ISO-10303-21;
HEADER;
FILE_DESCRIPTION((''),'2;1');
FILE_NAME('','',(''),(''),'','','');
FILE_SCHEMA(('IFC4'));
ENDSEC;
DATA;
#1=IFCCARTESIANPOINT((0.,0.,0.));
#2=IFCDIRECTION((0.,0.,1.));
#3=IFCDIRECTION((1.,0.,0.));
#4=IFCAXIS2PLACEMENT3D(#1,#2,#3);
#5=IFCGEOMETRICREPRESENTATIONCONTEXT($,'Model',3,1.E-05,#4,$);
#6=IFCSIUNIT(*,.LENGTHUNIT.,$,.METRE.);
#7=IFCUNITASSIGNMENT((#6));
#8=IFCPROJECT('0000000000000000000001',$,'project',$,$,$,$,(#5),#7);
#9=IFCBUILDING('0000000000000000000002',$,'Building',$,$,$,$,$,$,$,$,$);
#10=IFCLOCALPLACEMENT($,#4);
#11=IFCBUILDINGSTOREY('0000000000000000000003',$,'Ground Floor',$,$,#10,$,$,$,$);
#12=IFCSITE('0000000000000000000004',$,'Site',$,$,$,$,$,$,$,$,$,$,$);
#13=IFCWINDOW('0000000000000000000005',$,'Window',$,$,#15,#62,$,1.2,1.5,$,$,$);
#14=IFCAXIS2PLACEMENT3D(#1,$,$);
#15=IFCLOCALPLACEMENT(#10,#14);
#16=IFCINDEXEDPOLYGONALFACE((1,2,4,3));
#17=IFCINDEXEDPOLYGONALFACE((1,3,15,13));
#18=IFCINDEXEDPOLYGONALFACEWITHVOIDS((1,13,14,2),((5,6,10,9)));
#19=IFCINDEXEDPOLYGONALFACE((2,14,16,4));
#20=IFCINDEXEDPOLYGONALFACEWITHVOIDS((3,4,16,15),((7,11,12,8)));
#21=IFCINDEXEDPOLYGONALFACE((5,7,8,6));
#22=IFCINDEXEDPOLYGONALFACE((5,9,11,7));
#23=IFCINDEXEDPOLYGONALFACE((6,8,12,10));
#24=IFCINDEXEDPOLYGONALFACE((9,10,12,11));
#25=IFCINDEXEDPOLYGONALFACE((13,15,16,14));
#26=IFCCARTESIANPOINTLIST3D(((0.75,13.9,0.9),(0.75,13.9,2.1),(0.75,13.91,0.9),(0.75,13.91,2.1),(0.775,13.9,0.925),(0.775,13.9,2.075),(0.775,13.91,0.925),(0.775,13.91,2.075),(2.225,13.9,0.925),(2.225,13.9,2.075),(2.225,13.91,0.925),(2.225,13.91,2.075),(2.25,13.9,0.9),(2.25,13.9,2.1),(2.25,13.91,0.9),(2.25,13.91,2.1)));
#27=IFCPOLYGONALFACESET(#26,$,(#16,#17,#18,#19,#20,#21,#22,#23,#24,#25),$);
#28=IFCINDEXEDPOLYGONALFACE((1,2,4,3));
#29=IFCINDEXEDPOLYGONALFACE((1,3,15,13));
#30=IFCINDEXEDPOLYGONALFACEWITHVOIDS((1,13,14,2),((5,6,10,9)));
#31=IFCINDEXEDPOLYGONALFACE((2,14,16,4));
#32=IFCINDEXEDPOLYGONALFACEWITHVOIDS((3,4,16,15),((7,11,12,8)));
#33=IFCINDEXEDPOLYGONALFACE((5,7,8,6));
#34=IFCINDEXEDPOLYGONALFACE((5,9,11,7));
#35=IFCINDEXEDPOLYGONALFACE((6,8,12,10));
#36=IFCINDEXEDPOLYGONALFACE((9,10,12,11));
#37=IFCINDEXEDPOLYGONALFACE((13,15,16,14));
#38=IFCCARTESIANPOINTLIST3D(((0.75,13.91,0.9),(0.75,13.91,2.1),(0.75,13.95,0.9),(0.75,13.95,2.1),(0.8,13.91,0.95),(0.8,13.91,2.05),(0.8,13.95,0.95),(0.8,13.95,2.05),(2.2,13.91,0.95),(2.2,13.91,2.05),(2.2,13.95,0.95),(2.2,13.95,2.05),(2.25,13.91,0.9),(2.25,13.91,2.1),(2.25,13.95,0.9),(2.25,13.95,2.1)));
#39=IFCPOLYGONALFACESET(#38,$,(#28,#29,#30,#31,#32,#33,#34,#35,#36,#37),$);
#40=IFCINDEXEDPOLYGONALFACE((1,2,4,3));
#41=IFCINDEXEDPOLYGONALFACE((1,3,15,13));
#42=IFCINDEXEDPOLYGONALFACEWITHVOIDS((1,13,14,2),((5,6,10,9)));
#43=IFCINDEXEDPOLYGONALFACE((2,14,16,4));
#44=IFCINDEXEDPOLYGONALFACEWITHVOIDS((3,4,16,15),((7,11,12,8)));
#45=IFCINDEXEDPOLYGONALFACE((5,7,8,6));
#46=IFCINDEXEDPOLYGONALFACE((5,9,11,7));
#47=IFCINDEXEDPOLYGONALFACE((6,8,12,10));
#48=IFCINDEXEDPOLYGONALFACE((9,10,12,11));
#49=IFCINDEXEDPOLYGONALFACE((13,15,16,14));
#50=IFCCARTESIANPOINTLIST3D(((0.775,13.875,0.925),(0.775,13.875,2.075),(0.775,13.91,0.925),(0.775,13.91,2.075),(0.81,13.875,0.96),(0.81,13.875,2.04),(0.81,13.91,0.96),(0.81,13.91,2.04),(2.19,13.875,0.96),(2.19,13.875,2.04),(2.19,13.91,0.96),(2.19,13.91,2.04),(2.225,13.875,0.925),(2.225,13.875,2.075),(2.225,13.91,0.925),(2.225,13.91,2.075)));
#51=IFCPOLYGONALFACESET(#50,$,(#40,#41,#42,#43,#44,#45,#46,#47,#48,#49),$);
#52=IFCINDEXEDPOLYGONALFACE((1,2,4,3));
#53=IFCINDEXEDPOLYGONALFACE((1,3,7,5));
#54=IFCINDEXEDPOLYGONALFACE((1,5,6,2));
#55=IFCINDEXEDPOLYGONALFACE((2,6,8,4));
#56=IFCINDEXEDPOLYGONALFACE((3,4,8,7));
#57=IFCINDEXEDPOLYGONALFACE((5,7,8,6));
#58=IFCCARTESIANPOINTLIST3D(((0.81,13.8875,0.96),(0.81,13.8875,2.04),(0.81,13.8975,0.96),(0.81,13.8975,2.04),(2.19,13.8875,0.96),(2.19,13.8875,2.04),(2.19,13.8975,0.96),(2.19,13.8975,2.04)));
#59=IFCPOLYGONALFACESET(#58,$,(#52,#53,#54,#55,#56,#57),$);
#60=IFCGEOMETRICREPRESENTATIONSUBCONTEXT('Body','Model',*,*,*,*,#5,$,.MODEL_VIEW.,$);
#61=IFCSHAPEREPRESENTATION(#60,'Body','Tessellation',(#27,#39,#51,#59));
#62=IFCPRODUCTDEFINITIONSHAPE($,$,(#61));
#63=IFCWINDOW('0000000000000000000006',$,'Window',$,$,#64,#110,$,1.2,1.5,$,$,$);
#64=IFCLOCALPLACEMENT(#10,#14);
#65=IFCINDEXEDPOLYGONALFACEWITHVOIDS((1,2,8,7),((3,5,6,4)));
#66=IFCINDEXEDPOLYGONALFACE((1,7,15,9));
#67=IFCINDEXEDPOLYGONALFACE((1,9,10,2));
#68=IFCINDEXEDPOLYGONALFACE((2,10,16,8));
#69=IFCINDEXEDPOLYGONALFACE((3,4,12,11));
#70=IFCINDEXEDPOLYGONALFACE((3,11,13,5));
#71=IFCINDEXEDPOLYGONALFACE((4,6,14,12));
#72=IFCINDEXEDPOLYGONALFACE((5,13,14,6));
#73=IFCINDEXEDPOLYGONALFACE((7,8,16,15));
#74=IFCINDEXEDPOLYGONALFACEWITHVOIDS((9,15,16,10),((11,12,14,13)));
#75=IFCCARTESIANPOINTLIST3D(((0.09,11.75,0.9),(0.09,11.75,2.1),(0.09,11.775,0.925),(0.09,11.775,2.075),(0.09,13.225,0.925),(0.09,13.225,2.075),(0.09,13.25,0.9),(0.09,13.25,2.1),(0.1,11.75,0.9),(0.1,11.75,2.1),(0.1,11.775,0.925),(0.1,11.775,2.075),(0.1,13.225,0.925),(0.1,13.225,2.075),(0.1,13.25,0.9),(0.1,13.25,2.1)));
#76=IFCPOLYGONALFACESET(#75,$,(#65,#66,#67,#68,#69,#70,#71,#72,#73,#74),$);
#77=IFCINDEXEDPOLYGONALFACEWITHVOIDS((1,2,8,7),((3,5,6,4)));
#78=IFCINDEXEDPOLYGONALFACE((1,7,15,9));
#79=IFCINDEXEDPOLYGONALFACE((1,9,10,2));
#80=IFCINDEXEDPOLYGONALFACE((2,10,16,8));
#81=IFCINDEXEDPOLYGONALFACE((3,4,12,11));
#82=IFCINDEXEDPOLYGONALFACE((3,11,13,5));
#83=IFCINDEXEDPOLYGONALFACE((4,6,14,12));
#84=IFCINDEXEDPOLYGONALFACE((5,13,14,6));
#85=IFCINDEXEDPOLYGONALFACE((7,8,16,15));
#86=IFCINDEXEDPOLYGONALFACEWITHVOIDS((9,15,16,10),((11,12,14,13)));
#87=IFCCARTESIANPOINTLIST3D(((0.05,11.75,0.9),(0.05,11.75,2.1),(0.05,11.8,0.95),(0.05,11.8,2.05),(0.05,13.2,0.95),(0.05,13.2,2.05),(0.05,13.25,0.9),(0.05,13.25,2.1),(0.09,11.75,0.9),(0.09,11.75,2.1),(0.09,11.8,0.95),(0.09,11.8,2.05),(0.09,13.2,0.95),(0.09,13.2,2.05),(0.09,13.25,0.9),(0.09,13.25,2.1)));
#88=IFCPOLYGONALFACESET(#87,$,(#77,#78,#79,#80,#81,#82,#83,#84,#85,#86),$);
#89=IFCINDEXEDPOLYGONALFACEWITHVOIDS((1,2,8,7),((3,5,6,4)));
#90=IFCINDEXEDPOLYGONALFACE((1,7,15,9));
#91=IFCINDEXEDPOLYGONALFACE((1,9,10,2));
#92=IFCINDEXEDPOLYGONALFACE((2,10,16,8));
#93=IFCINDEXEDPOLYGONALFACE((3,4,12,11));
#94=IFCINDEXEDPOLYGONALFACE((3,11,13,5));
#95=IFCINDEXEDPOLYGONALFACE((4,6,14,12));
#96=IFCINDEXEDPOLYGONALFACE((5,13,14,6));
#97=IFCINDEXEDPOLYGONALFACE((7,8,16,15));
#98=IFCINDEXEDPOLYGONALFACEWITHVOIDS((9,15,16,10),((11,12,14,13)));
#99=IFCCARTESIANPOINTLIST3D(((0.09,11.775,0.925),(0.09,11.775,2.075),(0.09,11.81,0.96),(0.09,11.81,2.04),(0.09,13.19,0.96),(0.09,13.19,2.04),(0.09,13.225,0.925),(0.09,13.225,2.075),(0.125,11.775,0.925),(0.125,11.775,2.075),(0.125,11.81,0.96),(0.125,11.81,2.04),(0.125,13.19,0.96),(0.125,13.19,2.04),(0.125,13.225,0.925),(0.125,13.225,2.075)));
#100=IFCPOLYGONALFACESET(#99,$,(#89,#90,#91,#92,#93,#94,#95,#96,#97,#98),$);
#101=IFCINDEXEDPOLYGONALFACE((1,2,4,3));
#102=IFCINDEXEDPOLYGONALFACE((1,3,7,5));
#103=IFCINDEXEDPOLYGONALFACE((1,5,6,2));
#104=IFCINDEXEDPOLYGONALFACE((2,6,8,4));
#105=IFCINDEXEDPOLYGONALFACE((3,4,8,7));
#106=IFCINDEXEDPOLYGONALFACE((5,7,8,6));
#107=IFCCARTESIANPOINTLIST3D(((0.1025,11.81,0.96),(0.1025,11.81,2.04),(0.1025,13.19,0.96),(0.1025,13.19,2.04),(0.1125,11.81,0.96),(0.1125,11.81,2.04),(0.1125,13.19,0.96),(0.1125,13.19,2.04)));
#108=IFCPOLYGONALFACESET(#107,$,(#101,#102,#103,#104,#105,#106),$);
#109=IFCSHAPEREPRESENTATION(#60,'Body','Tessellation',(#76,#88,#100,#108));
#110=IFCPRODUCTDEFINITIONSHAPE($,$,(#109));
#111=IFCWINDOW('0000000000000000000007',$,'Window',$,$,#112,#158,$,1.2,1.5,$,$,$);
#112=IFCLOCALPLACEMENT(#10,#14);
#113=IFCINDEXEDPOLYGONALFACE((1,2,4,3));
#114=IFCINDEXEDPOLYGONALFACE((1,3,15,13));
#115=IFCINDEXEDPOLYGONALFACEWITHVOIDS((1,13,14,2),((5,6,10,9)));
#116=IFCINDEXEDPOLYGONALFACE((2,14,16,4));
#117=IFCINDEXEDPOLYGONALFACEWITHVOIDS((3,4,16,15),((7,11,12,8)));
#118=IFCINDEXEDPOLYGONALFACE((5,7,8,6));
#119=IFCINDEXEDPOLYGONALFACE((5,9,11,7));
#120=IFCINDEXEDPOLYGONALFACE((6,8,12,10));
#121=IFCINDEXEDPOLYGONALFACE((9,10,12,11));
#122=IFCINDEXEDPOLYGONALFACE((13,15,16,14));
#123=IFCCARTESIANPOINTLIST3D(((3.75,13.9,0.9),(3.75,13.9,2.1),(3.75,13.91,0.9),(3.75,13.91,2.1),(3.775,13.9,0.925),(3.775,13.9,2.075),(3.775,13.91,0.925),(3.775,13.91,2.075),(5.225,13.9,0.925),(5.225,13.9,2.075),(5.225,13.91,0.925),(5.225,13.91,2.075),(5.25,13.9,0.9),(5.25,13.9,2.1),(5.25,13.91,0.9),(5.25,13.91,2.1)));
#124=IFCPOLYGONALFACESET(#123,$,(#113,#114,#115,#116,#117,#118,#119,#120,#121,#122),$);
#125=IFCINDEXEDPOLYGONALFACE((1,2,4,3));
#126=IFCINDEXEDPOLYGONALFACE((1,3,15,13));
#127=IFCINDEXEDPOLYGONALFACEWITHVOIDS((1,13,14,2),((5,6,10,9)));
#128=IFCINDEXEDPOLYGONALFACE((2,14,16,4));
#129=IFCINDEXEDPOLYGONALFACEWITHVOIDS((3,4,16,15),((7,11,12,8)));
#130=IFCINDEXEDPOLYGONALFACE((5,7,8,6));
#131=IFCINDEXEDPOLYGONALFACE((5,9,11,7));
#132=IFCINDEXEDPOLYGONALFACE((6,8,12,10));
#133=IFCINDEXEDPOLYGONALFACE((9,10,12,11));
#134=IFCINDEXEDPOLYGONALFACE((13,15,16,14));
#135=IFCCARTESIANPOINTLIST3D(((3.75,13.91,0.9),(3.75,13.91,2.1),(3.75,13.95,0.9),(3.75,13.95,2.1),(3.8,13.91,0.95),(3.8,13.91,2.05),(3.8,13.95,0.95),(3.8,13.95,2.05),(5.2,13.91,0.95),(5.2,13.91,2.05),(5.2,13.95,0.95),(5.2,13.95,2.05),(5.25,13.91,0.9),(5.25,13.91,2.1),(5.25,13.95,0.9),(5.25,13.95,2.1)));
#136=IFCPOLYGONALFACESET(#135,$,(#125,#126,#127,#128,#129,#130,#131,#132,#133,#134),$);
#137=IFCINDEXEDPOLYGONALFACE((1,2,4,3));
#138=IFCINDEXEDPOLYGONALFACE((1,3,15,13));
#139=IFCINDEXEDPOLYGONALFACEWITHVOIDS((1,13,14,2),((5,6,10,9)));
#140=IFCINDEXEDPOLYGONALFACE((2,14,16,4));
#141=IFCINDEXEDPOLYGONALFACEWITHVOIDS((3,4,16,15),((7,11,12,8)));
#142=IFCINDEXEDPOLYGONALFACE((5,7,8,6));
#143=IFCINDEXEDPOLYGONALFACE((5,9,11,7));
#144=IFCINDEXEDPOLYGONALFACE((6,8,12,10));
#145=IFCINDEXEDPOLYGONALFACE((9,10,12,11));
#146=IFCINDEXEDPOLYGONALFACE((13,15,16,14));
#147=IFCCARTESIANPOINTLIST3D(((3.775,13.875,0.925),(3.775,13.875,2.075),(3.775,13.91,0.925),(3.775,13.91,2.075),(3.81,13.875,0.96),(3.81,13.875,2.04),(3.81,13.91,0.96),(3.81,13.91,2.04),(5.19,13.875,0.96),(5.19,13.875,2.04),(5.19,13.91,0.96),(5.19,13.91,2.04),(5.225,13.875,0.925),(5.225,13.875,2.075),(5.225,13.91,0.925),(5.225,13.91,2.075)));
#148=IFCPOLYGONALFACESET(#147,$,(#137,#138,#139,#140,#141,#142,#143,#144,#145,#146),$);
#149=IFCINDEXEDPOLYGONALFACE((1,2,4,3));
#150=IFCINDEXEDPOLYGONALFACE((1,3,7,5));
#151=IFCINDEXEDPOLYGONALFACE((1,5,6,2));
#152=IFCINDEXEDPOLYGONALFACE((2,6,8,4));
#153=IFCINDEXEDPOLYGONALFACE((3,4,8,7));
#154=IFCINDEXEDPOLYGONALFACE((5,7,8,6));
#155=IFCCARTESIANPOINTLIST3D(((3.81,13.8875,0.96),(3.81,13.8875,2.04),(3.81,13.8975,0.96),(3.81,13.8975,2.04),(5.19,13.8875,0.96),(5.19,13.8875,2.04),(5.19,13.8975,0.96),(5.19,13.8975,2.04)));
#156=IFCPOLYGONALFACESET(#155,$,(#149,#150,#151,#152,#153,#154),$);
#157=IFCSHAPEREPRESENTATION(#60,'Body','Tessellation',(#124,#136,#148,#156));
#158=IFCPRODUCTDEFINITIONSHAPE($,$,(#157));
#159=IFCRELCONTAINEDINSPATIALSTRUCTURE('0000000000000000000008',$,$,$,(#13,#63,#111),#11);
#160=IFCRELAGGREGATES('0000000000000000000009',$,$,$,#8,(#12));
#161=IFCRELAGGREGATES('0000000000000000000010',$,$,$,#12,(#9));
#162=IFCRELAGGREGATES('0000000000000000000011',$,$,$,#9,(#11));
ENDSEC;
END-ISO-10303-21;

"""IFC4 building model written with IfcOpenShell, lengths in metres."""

from ifc_helpers import new_model, si_unit, frame, origin_with_axes, place, context, subcontext, project, spatial, line, indexed_curve, outline, extrude, element, save


model = new_model("IFC4")

# Units and contexts
model_context = context("Model", 3, precision=1e-05, world=origin_with_axes())
body_context = subcontext(model_context, "Body", "Model", "MODEL_VIEW")
ifc_project = project(units=[si_unit("LENGTHUNIT", "METRE")], contexts=[model_context])

# Site, building, storey
site = spatial("IfcSite", under=ifc_project, Name="Site")
building = spatial("IfcBuilding", under=site, Name="Building")
storey_placement = place(None, origin_with_axes())
storey = spatial("IfcBuildingStorey", under=building, at=storey_placement, Name="Ground Floor")

# Windows
for number, where, z_axis, x_axis, name in (
    (1, (2.25, 14.0, 0.9), (0.0, 0.0, 1.0), (-1.0, 0.0, 0.0), "Window"),
    (2, (0.0, 13.25, 0.9), (0.0, 0.0, 1.0), (0.0, -1.0, 0.0), "Window"),
    (3, (5.25, 14.0, 0.9), (0.0, 0.0, 1.0), (-1.0, 0.0, 0.0), "Window"),
):
    element("IfcWindow", number, at=place(storey_placement, frame(where, z_axis=z_axis, x_axis=x_axis)), inside=storey, Name=name, OverallHeight=1.2, OverallWidth=1.5, context=body_context, shape_type="SweptSolid", body=[
        extrude(outline(indexed_curve([(0.0, 0.0), (1.5, 0.0), (1.5, 1.2), (0.0, 1.2)], segments=[line(1, 2, 3, 4, 1)]), holes=[indexed_curve([(0.025, 0.025), (1.475, 0.025), (1.475, 1.175), (0.025, 1.175)], segments=[line(1, 2, 3, 4, 1)])]), frame((0.0, 0.09, 0.0), z_axis=(0.0, -1.0, 0.0), x_axis=(1.0, 0.0, 0.0)), (0.0, 0.0, -1.0), 0.01),
        extrude(outline(indexed_curve([(0.0, 0.0), (1.5, 0.0), (1.5, 1.2), (0.0, 1.2)], segments=[line(1, 2, 3, 4, 1)]), holes=[indexed_curve([(0.05, 0.05), (1.45, 0.05), (1.45, 1.15), (0.05, 1.15)], segments=[line(1, 2, 3, 4, 1)])]), frame((0.0, 0.05, 0.0), z_axis=(0.0, -1.0, 0.0), x_axis=(1.0, 0.0, 0.0)), (0.0, 0.0, -1.0), 0.04),
        extrude(outline(indexed_curve([(0.0, 0.0), (1.45, 0.0), (1.45, 1.15), (0.0, 1.15)], segments=[line(1, 2, 3, 4, 1)]), holes=[indexed_curve([(0.035, 0.035), (1.415, 0.035), (1.415, 1.115), (0.035, 1.115)], segments=[line(1, 2, 3, 4, 1)])]), frame((0.025, 0.09, 0.025), z_axis=(0.0, -1.0, 0.0), x_axis=(1.0, 0.0, 0.0)), (0.0, 0.0, -1.0), 0.035),
        extrude(outline(indexed_curve([(0.035, 0.035), (1.415, 0.035), (1.415, 1.115), (0.035, 1.115)], segments=[line(1, 2, 3, 4, 1)])), frame((0.025, 0.1025, 0.025), z_axis=(0.0, -1.0, 0.0), x_axis=(1.0, 0.0, 0.0)), (0.0, 0.0, -1.0), 0.01),
    ])

save(model, "model.ifc")
